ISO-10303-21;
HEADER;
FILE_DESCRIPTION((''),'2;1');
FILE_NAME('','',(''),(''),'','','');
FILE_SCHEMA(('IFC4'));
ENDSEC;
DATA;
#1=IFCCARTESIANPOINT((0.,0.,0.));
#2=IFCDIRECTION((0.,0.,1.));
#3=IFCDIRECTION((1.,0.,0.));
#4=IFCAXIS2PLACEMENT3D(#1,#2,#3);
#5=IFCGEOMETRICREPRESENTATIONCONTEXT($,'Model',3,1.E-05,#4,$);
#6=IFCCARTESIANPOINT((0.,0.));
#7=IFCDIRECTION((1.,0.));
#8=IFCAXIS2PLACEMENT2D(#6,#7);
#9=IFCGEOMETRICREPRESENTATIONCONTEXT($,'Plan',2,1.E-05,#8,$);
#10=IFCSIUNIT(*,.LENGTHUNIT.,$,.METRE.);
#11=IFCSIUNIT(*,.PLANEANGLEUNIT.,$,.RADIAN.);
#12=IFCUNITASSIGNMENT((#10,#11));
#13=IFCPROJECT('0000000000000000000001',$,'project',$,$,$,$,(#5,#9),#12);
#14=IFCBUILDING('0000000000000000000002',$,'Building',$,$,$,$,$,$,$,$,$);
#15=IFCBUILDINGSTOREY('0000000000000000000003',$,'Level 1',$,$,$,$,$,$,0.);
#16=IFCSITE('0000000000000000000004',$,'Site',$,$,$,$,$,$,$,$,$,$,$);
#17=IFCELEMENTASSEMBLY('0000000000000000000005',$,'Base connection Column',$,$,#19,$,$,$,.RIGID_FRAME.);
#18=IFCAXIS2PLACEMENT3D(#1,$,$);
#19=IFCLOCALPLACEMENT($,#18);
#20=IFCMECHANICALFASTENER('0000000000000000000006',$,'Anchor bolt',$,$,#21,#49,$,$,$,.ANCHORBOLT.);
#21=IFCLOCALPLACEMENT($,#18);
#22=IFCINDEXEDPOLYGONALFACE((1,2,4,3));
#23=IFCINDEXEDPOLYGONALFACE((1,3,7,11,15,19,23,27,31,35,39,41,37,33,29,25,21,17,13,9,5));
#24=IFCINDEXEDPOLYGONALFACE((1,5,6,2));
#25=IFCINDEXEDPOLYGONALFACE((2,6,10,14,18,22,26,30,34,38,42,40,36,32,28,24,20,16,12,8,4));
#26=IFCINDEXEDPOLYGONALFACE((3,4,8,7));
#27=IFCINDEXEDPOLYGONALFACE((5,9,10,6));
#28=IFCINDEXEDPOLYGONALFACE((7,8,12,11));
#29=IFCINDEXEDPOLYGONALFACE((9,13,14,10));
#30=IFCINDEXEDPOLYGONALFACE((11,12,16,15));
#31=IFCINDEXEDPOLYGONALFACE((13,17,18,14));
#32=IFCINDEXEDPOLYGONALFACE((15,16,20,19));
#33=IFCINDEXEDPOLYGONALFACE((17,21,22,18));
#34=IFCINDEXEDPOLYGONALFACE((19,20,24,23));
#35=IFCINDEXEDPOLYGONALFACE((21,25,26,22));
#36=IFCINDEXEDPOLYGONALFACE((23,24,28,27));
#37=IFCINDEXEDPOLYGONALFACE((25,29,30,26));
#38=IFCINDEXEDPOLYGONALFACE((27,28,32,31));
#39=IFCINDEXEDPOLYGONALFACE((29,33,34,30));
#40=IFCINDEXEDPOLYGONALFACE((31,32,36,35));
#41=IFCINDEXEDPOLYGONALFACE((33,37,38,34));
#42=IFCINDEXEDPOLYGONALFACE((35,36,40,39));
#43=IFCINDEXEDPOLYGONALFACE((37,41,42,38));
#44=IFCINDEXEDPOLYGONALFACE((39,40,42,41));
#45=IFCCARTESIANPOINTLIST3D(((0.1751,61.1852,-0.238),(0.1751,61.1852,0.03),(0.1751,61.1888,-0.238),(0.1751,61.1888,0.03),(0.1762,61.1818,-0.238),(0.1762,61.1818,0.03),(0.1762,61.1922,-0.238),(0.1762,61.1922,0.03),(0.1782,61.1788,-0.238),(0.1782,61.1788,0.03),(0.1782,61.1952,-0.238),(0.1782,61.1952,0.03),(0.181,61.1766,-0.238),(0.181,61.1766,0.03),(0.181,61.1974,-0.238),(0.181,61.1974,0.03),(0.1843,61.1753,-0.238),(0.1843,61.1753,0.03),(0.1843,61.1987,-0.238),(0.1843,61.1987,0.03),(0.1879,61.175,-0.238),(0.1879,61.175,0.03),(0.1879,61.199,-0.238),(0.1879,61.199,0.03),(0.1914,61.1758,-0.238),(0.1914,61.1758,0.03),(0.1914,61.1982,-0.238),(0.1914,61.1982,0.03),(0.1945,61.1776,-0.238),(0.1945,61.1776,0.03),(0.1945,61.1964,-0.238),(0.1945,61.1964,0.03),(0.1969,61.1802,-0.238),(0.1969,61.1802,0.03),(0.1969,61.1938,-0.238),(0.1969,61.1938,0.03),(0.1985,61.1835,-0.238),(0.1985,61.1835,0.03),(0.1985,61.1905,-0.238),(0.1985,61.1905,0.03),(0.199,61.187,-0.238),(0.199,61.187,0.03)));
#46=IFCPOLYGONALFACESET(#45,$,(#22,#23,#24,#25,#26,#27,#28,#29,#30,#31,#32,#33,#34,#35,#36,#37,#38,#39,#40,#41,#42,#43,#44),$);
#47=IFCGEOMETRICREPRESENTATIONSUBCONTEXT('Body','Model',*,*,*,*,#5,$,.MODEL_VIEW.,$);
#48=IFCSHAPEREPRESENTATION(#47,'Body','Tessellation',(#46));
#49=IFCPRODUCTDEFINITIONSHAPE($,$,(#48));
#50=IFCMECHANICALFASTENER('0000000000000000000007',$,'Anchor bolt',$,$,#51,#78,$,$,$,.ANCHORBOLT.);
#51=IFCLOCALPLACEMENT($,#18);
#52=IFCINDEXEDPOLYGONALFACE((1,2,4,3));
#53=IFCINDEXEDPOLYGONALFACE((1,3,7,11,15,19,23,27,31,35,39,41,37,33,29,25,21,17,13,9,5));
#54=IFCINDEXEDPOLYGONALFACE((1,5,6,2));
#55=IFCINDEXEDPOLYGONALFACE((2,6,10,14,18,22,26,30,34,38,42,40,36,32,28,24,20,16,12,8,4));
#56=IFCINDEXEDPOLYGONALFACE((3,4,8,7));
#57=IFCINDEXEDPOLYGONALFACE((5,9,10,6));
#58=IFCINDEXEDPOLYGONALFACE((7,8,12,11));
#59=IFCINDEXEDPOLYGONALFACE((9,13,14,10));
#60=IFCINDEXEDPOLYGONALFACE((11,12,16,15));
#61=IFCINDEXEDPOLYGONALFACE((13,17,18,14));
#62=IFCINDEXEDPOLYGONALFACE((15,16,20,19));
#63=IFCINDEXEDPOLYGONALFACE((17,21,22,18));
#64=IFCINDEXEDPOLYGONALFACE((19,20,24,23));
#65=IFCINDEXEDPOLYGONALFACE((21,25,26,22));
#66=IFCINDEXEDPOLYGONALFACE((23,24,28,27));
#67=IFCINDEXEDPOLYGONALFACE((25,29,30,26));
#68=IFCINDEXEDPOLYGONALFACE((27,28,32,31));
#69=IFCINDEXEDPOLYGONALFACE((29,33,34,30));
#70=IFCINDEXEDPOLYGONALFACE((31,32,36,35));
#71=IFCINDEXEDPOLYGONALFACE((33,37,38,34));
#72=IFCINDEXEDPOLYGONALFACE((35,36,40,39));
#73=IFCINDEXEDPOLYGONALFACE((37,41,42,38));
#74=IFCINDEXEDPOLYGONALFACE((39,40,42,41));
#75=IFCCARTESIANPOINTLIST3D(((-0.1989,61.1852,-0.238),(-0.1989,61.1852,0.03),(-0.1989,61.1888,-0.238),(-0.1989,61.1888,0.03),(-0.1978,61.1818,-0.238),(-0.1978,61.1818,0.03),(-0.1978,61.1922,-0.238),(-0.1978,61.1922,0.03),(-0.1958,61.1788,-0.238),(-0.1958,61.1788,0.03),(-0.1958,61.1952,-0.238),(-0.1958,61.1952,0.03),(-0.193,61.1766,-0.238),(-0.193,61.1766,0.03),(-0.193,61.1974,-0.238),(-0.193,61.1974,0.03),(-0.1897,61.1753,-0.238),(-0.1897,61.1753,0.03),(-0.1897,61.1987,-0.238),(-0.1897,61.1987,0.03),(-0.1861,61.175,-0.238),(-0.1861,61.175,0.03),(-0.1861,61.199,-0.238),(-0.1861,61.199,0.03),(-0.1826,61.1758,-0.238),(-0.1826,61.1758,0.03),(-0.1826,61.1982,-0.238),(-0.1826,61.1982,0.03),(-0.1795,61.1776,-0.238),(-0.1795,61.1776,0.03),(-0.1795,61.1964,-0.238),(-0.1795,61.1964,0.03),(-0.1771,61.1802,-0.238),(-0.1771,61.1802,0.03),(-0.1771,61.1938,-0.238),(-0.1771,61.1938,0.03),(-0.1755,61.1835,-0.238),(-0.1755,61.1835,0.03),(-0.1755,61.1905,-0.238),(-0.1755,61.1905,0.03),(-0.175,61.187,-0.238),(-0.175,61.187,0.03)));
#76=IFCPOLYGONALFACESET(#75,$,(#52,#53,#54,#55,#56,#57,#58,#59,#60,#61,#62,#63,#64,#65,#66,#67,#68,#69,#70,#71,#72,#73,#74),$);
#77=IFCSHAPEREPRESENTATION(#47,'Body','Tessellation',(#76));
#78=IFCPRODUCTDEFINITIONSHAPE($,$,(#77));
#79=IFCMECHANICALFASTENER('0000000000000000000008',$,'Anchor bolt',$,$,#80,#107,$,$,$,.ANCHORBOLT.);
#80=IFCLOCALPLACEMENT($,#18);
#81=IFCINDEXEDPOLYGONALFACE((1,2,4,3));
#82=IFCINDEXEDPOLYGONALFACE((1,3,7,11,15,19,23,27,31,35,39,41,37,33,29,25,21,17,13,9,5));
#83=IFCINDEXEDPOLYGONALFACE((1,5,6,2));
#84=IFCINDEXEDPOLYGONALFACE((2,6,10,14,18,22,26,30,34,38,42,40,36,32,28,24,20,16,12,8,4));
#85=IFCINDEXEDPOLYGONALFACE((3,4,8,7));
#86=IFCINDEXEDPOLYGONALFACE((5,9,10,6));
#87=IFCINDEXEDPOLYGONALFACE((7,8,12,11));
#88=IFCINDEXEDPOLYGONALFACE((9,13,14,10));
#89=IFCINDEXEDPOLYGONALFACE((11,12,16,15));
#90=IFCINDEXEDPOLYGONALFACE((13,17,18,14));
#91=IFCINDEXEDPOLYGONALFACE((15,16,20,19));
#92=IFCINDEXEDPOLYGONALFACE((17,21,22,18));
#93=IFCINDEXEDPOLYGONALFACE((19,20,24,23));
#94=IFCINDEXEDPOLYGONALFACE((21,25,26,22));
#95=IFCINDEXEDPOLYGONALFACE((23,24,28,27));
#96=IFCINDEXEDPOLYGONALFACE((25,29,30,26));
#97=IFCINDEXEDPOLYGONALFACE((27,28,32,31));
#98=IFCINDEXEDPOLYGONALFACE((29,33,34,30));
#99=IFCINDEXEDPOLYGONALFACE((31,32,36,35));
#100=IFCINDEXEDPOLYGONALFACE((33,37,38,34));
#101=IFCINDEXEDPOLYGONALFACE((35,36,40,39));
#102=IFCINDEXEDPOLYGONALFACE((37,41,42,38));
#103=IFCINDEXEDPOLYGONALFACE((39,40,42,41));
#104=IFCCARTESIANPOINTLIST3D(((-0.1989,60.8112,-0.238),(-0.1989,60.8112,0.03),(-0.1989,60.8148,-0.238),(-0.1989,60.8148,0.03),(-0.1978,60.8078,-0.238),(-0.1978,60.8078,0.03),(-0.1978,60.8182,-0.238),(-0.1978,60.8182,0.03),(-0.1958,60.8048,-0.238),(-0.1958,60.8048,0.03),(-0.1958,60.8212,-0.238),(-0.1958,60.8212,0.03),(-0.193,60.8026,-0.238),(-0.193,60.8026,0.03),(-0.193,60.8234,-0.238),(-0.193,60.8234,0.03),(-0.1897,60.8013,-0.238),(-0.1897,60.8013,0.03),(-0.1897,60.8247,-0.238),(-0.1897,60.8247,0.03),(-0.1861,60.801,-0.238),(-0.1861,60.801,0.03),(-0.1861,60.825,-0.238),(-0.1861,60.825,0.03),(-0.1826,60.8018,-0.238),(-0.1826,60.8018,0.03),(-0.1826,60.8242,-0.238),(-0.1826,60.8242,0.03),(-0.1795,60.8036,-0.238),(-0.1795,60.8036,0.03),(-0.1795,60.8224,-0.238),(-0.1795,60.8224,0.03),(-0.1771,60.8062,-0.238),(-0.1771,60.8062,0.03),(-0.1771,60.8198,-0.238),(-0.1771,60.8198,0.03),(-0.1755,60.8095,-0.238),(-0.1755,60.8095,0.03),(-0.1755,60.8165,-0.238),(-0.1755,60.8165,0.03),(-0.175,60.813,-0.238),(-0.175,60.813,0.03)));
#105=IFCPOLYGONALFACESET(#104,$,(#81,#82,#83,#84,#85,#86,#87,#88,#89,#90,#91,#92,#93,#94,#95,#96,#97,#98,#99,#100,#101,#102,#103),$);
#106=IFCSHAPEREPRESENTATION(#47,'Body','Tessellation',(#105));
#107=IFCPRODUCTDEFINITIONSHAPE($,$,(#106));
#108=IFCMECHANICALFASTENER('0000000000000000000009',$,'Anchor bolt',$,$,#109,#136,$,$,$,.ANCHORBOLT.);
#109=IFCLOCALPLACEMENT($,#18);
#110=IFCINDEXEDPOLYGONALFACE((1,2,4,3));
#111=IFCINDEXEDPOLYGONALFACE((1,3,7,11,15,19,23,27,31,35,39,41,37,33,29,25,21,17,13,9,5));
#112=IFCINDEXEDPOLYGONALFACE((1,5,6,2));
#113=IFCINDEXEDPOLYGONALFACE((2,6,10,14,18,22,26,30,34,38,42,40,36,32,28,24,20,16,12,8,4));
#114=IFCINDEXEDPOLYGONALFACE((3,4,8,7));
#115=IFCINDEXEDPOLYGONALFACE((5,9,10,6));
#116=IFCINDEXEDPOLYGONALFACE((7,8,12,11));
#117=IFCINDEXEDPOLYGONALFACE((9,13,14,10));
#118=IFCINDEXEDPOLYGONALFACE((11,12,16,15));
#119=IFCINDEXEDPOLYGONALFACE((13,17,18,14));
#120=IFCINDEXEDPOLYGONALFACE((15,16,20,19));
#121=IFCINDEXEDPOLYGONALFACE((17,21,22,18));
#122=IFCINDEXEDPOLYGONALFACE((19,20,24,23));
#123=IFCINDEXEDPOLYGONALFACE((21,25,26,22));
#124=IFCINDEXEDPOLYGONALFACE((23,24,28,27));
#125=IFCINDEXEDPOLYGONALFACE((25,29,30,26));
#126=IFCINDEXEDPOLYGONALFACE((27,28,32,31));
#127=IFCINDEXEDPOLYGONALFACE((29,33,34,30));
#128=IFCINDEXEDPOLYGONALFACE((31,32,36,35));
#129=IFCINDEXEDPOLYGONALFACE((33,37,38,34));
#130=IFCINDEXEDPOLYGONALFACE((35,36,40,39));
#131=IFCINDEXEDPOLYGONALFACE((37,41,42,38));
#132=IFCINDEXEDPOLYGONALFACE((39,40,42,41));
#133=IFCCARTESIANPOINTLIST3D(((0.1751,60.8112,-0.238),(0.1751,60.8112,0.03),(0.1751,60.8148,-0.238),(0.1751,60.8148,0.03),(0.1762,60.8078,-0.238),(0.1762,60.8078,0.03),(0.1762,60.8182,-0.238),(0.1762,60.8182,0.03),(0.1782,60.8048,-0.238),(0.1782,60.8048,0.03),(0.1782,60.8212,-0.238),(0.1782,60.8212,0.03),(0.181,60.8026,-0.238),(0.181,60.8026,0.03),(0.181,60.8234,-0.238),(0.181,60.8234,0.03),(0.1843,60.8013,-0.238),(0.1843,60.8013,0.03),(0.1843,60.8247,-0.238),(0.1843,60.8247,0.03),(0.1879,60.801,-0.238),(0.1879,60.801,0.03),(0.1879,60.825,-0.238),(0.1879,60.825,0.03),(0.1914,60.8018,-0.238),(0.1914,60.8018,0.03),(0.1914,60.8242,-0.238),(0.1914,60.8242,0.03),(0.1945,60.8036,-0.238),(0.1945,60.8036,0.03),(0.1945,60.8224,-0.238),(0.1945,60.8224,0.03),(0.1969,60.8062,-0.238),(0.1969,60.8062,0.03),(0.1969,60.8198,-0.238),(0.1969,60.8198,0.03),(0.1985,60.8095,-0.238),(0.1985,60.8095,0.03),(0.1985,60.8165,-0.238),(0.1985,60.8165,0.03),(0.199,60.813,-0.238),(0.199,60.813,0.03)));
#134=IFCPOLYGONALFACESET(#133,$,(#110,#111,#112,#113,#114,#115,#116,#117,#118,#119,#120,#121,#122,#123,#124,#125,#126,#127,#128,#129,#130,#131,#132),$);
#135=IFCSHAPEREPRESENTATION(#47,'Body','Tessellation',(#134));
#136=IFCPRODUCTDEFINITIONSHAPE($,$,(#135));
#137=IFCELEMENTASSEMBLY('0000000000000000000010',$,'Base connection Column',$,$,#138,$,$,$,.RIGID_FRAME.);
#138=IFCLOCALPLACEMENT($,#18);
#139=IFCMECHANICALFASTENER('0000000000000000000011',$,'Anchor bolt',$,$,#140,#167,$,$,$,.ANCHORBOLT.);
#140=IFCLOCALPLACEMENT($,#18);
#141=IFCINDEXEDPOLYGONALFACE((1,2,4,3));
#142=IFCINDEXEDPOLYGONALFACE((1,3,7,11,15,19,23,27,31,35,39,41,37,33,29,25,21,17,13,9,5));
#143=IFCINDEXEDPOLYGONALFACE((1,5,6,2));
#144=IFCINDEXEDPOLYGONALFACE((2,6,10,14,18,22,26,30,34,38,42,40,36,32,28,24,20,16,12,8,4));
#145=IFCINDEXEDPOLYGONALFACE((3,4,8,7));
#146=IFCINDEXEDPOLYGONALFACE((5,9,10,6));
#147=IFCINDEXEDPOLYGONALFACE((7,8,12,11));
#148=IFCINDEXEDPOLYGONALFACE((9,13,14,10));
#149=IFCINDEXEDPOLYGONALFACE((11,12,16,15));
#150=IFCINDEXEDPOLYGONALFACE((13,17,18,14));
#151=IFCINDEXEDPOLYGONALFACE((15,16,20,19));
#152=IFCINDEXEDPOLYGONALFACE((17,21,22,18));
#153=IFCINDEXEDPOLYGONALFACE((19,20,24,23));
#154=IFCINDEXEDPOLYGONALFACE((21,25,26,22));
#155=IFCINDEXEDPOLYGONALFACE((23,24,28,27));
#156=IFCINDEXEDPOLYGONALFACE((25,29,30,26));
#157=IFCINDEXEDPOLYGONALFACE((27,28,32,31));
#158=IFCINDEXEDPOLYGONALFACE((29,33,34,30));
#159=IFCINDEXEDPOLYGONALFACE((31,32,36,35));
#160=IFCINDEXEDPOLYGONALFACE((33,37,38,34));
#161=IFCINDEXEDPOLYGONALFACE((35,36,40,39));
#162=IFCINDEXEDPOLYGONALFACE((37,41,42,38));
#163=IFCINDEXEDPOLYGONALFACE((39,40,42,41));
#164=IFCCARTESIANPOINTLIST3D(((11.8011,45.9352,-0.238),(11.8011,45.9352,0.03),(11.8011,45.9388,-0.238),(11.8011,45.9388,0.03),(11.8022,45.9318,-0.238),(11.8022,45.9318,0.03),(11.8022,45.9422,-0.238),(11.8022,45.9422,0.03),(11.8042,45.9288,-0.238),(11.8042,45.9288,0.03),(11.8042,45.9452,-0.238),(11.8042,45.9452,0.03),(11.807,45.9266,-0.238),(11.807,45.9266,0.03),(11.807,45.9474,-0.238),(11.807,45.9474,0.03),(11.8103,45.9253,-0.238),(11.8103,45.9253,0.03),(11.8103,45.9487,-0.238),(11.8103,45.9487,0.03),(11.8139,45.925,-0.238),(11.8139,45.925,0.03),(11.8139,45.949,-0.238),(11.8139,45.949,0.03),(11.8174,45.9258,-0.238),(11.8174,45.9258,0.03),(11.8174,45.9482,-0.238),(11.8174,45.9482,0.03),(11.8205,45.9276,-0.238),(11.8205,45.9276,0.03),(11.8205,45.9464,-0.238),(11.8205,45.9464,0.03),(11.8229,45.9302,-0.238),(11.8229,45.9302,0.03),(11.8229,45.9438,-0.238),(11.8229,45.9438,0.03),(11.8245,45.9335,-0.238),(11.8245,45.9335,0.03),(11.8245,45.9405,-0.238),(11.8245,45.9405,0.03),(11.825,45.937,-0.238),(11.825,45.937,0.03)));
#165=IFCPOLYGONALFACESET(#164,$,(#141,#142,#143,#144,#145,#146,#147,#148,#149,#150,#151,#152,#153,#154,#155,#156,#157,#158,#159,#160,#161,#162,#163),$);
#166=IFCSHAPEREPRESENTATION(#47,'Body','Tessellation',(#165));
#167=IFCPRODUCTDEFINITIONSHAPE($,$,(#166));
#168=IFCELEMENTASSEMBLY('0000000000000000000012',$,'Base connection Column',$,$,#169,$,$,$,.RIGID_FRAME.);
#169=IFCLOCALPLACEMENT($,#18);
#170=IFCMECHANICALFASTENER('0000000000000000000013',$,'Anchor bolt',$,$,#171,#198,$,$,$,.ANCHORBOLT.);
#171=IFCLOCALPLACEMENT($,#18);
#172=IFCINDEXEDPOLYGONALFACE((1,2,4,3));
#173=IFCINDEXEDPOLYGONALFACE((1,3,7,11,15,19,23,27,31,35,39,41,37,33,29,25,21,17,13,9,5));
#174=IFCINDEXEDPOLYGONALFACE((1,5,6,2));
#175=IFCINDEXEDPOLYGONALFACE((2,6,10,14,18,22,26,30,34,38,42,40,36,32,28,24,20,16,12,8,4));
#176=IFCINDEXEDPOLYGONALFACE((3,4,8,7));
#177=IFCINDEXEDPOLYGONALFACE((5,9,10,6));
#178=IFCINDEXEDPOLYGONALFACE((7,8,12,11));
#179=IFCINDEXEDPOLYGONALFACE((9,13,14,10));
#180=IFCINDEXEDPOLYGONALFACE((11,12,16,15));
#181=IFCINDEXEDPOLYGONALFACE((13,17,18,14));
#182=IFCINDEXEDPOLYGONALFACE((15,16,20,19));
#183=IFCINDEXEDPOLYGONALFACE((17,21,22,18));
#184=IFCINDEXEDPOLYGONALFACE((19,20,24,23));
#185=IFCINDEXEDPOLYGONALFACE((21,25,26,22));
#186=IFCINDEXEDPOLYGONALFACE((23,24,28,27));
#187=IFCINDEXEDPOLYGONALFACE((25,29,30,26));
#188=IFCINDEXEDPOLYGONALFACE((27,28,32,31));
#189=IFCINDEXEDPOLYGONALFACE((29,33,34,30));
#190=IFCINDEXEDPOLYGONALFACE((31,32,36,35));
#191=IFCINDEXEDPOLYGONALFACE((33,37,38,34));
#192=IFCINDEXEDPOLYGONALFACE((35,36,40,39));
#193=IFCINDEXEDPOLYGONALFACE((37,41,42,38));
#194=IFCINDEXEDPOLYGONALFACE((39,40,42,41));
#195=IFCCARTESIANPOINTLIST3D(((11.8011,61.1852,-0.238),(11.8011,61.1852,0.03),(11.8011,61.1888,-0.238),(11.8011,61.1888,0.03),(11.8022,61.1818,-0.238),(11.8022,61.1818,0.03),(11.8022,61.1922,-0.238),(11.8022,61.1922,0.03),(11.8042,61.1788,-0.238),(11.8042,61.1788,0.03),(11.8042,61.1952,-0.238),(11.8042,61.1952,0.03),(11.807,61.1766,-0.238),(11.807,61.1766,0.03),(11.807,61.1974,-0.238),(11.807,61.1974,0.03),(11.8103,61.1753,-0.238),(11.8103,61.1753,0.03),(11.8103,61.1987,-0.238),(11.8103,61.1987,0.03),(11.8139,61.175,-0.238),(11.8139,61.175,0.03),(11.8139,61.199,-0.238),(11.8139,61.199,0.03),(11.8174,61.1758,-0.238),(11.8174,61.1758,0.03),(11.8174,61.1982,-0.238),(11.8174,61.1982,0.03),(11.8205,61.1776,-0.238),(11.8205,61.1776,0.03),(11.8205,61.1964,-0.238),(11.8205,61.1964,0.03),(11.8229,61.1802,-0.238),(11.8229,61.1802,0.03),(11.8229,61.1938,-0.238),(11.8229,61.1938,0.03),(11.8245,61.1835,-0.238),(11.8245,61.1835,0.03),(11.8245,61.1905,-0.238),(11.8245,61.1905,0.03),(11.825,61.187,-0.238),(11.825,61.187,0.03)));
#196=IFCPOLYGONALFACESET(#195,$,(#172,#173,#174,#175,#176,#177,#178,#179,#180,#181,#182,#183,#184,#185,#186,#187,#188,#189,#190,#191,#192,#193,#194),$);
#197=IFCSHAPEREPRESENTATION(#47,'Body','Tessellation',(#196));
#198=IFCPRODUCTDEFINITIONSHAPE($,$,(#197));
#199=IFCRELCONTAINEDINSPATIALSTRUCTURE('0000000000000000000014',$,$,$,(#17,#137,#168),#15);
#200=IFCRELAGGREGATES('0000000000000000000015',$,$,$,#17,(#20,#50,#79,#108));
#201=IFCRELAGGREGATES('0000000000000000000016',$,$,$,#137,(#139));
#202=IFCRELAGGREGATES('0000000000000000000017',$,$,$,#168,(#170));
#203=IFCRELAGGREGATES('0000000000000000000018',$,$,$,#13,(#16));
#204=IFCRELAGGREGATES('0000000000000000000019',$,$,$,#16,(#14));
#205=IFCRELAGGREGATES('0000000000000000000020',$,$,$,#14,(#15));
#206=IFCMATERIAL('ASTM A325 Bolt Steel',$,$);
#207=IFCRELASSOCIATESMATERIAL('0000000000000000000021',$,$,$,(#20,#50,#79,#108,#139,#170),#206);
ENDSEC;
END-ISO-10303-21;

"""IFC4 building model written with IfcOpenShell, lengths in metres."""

from ifc_helpers import new_model, si_unit, frame, origin_with_axes, origin_2d, origin_2d_with_axis, place, context, subcontext, project, spatial, circle, extrude, material, element, aggregate, save


model = new_model("IFC4")

# Units and contexts
model_context = context("Model", 3, precision=1e-05, world=origin_with_axes())
plan_context = context("Plan", 2, precision=1e-05, world=origin_2d_with_axis())
body_context = subcontext(model_context, "Body", "Model", "MODEL_VIEW")
ifc_project = project(units=[si_unit("LENGTHUNIT", "METRE"), si_unit("PLANEANGLEUNIT", "RADIAN")], contexts=[model_context, plan_context])

# Site, building, storey
site = spatial("IfcSite", under=ifc_project, Name="Site")
building = spatial("IfcBuilding", under=site, Name="Building")
storey = spatial("IfcBuildingStorey", under=building, Name="Level 1", Elevation=0.0)

# Element assembly
assembly_1 = element("IfcElementAssembly", 1, inside=storey, Name="Base connection Column", PredefinedType="RIGID_FRAME")

# Shared definitions
ifc_material_1 = material(Name="ASTM A325 Bolt Steel")

# Mechanical fasteners
mechanical_fastener_1_placement = place(None, frame((0.187, 61.187, -0.238), z_axis=(0.0, 0.0, 1.0), x_axis=(1.0, 0.0, 0.0)))
mechanical_fastener_1 = element("IfcMechanicalFastener", 2, at=mechanical_fastener_1_placement, material=ifc_material_1, Name="Anchor bolt", PredefinedType="ANCHORBOLT", context=body_context, shape_type="SweptSolid", body=[
    extrude(circle(Radius=0.012, at=origin_2d()), origin_with_axes(), (0.0, 0.0, 1.0), 0.268),
])
mechanical_fastener_2_placement = place(None, frame((-0.187, 61.187, -0.238), z_axis=(0.0, 0.0, 1.0), x_axis=(1.0, 0.0, 0.0)))
mechanical_fastener_2 = element("IfcMechanicalFastener", 3, at=mechanical_fastener_2_placement, material=ifc_material_1, Name="Anchor bolt", PredefinedType="ANCHORBOLT", context=body_context, shape_type="SweptSolid", body=[
    extrude(circle(Radius=0.012, at=origin_2d()), origin_with_axes(), (0.0, 0.0, 1.0), 0.268),
])
mechanical_fastener_3_placement = place(None, frame((-0.187, 60.813, -0.238), z_axis=(0.0, 0.0, 1.0), x_axis=(1.0, 0.0, 0.0)))
mechanical_fastener_3 = element("IfcMechanicalFastener", 4, at=mechanical_fastener_3_placement, material=ifc_material_1, Name="Anchor bolt", PredefinedType="ANCHORBOLT", context=body_context, shape_type="SweptSolid", body=[
    extrude(circle(Radius=0.012, at=origin_2d()), origin_with_axes(), (0.0, 0.0, 1.0), 0.268),
])
mechanical_fastener_4_placement = place(None, frame((0.187, 60.813, -0.238), z_axis=(0.0, 0.0, 1.0), x_axis=(1.0, 0.0, 0.0)))
mechanical_fastener_4 = element("IfcMechanicalFastener", 5, at=mechanical_fastener_4_placement, material=ifc_material_1, Name="Anchor bolt", PredefinedType="ANCHORBOLT", context=body_context, shape_type="SweptSolid", body=[
    extrude(circle(Radius=0.012, at=origin_2d()), origin_with_axes(), (0.0, 0.0, 1.0), 0.268),
])
aggregate(assembly_1, [mechanical_fastener_1, mechanical_fastener_2, mechanical_fastener_3, mechanical_fastener_4])

# Element assembly, mechanical fastener
assembly_2 = element("IfcElementAssembly", 6, inside=storey, Name="Base connection Column", PredefinedType="RIGID_FRAME")
mechanical_fastener_5_placement = place(None, frame((11.813, 45.937, -0.238), z_axis=(0.0, 0.0, 1.0), x_axis=(1.0, 0.0, 0.0)))
mechanical_fastener_5 = element("IfcMechanicalFastener", 7, at=mechanical_fastener_5_placement, material=ifc_material_1, Name="Anchor bolt", PredefinedType="ANCHORBOLT", context=body_context, shape_type="SweptSolid", body=[
    extrude(circle(Radius=0.012, at=origin_2d()), origin_with_axes(), (0.0, 0.0, 1.0), 0.268),
])
aggregate(assembly_2, [mechanical_fastener_5])

# Element assembly, mechanical fastener
assembly_3 = element("IfcElementAssembly", 8, inside=storey, Name="Base connection Column", PredefinedType="RIGID_FRAME")
mechanical_fastener_6_placement = place(None, frame((11.813, 61.187, -0.238), z_axis=(0.0, 0.0, 1.0), x_axis=(1.0, 0.0, 0.0)))
mechanical_fastener_6 = element("IfcMechanicalFastener", 9, at=mechanical_fastener_6_placement, material=ifc_material_1, Name="Anchor bolt", PredefinedType="ANCHORBOLT", context=body_context, shape_type="SweptSolid", body=[
    extrude(circle(Radius=0.012, at=origin_2d()), origin_with_axes(), (0.0, 0.0, 1.0), 0.268),
])
aggregate(assembly_3, [mechanical_fastener_6])

save(model, "model.ifc")
